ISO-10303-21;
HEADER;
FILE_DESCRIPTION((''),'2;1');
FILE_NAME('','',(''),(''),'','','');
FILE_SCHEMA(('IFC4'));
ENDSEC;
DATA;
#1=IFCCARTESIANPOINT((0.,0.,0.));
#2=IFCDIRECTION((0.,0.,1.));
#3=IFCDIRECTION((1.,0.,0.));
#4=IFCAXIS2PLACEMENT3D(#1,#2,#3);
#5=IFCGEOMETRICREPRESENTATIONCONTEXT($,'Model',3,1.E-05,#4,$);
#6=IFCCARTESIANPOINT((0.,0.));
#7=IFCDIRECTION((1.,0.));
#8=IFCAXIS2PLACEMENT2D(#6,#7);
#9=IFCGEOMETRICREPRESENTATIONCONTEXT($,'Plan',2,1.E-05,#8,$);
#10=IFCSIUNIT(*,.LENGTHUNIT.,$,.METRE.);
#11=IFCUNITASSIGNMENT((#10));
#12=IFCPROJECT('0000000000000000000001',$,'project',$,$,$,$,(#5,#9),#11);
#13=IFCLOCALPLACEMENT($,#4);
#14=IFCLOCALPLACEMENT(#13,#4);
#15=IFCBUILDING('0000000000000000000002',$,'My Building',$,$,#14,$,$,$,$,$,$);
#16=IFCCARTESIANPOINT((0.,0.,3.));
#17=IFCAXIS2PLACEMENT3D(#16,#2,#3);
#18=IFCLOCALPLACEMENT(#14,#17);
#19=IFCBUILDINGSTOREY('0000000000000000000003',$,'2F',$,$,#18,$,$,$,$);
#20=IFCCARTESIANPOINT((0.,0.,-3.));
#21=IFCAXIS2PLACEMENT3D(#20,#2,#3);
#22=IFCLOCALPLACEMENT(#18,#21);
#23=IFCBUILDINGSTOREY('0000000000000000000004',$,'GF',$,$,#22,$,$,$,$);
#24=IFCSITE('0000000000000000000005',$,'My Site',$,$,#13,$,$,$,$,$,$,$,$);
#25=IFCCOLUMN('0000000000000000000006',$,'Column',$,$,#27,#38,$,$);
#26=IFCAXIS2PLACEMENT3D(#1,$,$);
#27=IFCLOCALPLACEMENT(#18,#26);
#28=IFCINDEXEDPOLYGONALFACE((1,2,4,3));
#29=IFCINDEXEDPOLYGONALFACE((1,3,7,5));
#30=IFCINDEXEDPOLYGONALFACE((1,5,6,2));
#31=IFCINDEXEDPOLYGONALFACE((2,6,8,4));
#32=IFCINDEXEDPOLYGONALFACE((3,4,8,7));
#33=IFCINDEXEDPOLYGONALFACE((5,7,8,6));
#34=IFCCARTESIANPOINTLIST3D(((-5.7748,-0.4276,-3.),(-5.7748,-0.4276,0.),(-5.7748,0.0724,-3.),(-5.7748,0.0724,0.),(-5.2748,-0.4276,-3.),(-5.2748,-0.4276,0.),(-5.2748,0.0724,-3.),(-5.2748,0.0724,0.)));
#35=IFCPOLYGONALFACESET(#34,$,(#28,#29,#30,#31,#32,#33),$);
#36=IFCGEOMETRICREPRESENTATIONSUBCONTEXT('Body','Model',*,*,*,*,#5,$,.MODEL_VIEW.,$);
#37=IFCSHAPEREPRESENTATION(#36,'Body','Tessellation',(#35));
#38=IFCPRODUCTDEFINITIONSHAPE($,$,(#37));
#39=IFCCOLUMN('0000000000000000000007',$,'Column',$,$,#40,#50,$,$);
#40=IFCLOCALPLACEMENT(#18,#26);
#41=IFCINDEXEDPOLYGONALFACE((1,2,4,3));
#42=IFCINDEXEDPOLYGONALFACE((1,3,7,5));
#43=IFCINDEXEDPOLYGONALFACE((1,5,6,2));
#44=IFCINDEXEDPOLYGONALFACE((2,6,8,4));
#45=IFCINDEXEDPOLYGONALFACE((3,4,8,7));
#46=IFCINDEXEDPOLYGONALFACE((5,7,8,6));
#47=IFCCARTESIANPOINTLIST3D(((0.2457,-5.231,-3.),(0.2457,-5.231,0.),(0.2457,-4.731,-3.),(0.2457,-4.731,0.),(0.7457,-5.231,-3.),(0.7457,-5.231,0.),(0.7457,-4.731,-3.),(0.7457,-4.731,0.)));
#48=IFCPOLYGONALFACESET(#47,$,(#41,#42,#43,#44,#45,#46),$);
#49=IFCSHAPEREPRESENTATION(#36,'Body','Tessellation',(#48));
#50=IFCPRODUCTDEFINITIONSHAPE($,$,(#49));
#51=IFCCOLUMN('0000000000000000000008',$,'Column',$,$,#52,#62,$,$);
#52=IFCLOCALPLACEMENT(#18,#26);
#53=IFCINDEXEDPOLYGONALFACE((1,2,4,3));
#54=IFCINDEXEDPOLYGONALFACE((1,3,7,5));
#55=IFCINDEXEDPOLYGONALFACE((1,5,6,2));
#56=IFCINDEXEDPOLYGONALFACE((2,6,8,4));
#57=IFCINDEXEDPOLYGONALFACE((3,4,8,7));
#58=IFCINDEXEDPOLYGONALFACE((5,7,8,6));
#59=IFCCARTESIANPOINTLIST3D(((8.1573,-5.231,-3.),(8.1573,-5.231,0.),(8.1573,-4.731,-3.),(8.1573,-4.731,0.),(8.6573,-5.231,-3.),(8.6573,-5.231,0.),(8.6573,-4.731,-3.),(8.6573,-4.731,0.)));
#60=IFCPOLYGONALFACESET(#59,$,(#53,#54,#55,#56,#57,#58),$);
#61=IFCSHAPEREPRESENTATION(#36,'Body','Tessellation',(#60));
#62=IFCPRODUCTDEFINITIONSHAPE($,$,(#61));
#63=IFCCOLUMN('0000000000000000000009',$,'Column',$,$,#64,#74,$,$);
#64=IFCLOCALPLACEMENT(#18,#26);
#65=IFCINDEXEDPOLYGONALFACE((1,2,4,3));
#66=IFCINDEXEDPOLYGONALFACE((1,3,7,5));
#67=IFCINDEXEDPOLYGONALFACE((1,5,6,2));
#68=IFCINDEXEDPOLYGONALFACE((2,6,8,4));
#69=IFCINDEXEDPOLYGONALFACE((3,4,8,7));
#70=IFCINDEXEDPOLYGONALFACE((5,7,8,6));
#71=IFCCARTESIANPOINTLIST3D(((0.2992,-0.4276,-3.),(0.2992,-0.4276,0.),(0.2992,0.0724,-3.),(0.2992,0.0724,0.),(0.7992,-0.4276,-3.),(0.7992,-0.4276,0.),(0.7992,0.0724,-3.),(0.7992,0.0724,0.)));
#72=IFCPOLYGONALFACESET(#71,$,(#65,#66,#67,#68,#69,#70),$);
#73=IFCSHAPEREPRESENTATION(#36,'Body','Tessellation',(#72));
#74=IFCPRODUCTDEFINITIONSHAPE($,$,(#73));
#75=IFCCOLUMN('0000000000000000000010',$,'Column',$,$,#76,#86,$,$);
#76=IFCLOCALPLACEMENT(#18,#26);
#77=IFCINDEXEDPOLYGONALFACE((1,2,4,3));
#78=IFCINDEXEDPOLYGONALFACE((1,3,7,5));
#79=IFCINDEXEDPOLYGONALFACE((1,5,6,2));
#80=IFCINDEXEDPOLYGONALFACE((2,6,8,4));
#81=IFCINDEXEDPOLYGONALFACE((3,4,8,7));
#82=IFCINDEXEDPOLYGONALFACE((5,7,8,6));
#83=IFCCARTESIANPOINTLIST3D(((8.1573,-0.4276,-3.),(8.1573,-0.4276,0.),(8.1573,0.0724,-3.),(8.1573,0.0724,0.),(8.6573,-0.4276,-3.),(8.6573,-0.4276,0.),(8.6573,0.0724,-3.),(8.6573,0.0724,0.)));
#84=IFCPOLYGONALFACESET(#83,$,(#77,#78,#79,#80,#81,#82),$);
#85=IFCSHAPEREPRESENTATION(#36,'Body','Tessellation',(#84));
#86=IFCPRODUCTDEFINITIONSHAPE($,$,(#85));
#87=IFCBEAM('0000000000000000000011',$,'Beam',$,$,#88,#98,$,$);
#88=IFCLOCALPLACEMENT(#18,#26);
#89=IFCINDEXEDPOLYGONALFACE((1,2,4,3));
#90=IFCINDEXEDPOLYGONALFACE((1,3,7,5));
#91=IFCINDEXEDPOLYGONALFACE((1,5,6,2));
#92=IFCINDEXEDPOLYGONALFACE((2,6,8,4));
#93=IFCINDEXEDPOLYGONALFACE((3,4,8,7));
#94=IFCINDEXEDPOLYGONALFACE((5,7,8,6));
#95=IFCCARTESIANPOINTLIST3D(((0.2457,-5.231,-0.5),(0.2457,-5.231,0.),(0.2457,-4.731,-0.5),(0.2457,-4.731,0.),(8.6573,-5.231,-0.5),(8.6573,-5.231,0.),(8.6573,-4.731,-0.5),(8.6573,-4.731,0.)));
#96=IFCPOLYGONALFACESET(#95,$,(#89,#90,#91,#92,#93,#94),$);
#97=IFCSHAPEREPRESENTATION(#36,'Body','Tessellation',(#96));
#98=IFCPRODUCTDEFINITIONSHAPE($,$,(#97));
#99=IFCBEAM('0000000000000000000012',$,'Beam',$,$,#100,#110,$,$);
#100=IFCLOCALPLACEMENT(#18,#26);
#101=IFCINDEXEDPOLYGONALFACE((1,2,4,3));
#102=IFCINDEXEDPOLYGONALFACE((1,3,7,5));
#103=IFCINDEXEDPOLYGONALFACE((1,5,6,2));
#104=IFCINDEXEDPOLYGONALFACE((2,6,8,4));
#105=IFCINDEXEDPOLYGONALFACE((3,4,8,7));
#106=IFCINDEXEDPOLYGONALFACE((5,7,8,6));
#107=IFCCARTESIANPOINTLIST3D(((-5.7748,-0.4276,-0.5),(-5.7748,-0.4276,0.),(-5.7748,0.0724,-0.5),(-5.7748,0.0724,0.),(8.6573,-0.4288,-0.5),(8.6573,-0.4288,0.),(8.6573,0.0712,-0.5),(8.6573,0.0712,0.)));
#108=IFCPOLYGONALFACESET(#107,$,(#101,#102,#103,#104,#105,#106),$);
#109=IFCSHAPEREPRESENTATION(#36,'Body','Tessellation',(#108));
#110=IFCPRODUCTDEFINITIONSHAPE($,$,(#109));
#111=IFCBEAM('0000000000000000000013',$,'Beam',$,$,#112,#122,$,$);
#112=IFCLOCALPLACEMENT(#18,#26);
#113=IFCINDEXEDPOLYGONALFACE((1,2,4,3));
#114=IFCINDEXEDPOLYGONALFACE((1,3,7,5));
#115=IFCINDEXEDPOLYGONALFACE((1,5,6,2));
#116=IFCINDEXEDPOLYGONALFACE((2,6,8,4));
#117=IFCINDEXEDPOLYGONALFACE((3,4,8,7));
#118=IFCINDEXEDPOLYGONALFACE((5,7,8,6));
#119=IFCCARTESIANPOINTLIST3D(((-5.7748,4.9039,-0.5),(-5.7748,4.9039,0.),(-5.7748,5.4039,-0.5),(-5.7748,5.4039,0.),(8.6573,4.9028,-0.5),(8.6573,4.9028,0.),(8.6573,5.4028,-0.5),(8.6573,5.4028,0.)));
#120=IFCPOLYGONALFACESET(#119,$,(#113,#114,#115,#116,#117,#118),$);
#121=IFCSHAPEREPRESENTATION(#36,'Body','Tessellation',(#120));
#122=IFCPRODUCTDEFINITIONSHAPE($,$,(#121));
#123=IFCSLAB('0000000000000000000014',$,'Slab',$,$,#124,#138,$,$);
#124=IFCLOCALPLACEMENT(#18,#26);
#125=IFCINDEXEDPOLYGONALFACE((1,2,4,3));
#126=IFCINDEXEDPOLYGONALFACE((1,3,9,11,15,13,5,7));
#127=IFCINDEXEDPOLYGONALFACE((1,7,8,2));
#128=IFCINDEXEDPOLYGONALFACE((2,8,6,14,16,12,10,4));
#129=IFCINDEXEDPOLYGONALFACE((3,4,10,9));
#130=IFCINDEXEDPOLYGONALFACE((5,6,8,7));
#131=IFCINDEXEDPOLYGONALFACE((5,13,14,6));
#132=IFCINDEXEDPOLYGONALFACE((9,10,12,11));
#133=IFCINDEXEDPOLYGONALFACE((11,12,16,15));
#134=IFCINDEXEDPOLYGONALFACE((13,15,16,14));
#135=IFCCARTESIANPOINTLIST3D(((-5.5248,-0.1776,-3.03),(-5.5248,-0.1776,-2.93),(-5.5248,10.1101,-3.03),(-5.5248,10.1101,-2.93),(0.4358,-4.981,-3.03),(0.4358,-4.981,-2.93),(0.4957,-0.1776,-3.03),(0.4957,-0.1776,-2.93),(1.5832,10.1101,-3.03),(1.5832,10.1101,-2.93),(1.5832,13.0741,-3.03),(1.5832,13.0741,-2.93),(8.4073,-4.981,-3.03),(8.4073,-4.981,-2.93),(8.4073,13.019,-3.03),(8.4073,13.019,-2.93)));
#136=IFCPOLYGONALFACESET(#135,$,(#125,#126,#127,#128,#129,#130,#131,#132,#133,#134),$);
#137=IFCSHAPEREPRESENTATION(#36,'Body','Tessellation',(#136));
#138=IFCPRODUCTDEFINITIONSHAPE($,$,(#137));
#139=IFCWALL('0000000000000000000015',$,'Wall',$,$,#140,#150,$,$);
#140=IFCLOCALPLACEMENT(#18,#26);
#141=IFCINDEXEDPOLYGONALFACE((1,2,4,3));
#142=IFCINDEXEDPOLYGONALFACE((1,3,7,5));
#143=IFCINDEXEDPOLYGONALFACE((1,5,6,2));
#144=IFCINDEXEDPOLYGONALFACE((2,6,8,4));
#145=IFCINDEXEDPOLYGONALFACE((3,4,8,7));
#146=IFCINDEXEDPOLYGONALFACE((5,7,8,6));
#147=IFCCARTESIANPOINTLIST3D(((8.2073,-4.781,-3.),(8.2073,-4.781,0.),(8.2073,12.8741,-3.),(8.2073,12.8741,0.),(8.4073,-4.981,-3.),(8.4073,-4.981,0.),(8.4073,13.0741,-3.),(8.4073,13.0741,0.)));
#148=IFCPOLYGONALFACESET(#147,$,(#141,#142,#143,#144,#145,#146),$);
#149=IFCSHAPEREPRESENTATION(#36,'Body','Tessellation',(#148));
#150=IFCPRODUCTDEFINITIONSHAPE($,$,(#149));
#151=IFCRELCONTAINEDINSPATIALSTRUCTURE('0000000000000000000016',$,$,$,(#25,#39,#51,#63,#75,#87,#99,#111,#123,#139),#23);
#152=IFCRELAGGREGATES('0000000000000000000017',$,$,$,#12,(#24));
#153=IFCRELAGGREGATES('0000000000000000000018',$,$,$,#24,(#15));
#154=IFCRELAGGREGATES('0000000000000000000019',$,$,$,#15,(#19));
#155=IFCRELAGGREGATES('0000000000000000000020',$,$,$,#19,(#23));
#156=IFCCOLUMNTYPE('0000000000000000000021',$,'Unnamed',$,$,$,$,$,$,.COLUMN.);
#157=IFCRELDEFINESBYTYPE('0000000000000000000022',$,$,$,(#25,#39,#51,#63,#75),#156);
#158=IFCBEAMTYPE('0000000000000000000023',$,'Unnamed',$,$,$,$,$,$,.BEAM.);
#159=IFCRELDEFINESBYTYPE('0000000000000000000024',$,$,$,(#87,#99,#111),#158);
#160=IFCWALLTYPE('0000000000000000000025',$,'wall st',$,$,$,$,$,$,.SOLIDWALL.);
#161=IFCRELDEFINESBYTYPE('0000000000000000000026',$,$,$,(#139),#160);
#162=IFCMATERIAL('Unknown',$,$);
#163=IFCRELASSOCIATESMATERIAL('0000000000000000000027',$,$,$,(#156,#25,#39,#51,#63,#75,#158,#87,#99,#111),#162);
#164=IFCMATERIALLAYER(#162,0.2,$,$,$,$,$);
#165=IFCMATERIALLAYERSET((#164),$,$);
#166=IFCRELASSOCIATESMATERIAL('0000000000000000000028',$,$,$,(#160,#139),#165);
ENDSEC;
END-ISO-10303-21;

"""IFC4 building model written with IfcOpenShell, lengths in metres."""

from ifc_helpers import new_model, si_unit, frame, origin_with_axes, origin_2d_with_axis, place, context, subcontext, project, spatial, line, indexed_curve, rectangle, outline, extrude, material, layer, layer_set, layer_usage, material_profile, profile_set, profile_usage, type_object, element, save


model = new_model("IFC4")

# Units and contexts
model_context = context("Model", 3, precision=1e-05, world=origin_with_axes())
plan_context = context("Plan", 2, precision=1e-05, world=origin_2d_with_axis())
body_context_1 = subcontext(model_context, "Body", "Model", "MODEL_VIEW")
ifc_project = project(units=[si_unit("LENGTHUNIT", "METRE")], contexts=[model_context, plan_context])

# Site, building, storeys
site_placement = place(None, origin_with_axes())
site = spatial("IfcSite", under=ifc_project, at=site_placement, Name="My Site")
building_placement = place(site_placement, origin_with_axes())
building = spatial("IfcBuilding", under=site, at=building_placement, Name="My Building")
storey_1_placement = place(building_placement, frame((0.0, 0.0, 3.0), z_axis=(0.0, 0.0, 1.0), x_axis=(1.0, 0.0, 0.0)))
storey_1 = spatial("IfcBuildingStorey", under=building, at=storey_1_placement, Name="2F")
storey_2_placement = place(storey_1_placement, frame((0.0, 0.0, -3.0), z_axis=(0.0, 0.0, 1.0), x_axis=(1.0, 0.0, 0.0)))
storey_2 = spatial("IfcBuildingStorey", under=storey_1, at=storey_2_placement, Name="GF")

# Columns
ifc_material = material(Name="Unknown")
ifc_material_profile_1 = material_profile(ifc_material, rectangle(XDim=0.5, YDim=0.5))
ifc_profile_set_1 = profile_set([ifc_material_profile_1])
ifc_profile_usage_1 = profile_usage(ifc_profile_set_1, cardinal=5)
column_type = type_object("IfcColumnType", Name="Unnamed", PredefinedType="COLUMN", material=ifc_profile_set_1)
column_1_placement = place(storey_2_placement, frame((-5.5248, -0.1776, 0.0), z_axis=(0.0, 0.0, 1.0), x_axis=(1.0, 0.0, 0.0)))
element("IfcColumn", 1, at=column_1_placement, inside=storey_2, type_object=column_type, material=ifc_profile_usage_1, Name="Column", context=body_context_1, shape_type="SweptSolid", body=[
    extrude(rectangle(XDim=0.5, YDim=0.5), origin_with_axes(), (0.0, 0.0, 1.0), 3.0),
])
ifc_profile_usage_2 = profile_usage(ifc_profile_set_1, cardinal=5)
column_2_placement = place(storey_2_placement, frame((0.4957, -4.981, 0.0), z_axis=(0.0, 0.0, 1.0), x_axis=(1.0, 0.0, 0.0)))
element("IfcColumn", 2, at=column_2_placement, inside=storey_2, type_object=column_type, material=ifc_profile_usage_2, Name="Column", context=body_context_1, shape_type="SweptSolid", body=[
    extrude(rectangle(XDim=0.5, YDim=0.5), origin_with_axes(), (0.0, 0.0, 1.0), 3.0),
])
ifc_profile_usage_3 = profile_usage(ifc_profile_set_1, cardinal=5)
column_3_placement = place(storey_2_placement, frame((8.4073, -4.981, 0.0), z_axis=(0.0, 0.0, 1.0), x_axis=(1.0, 0.0, 0.0)))
element("IfcColumn", 3, at=column_3_placement, inside=storey_2, type_object=column_type, material=ifc_profile_usage_3, Name="Column", context=body_context_1, shape_type="SweptSolid", body=[
    extrude(rectangle(XDim=0.5, YDim=0.5), origin_with_axes(), (0.0, 0.0, 1.0), 3.0),
])
ifc_profile_usage_4 = profile_usage(ifc_profile_set_1, cardinal=5)
column_4_placement = place(storey_2_placement, frame((0.5492, -0.1776, 0.0), z_axis=(0.0, 0.0, 1.0), x_axis=(1.0, 0.0, 0.0)))
element("IfcColumn", 4, at=column_4_placement, inside=storey_2, type_object=column_type, material=ifc_profile_usage_4, Name="Column", context=body_context_1, shape_type="SweptSolid", body=[
    extrude(rectangle(XDim=0.5, YDim=0.5), origin_with_axes(), (0.0, 0.0, 1.0), 3.0),
])
ifc_profile_usage_5 = profile_usage(ifc_profile_set_1, cardinal=5)
column_5_placement = place(storey_2_placement, frame((8.4073, -0.1776, 0.0), z_axis=(0.0, 0.0, 1.0), x_axis=(1.0, 0.0, 0.0)))
element("IfcColumn", 5, at=column_5_placement, inside=storey_2, type_object=column_type, material=ifc_profile_usage_5, Name="Column", context=body_context_1, shape_type="SweptSolid", body=[
    extrude(rectangle(XDim=0.5, YDim=0.5), origin_with_axes(), (0.0, 0.0, 1.0), 3.0),
])

# Beams
ifc_material_profile_2 = material_profile(ifc_material, rectangle(XDim=0.5, YDim=0.5))
ifc_profile_set_2 = profile_set([ifc_material_profile_2])
ifc_profile_usage_6 = profile_usage(ifc_profile_set_2, cardinal=6)
beam_type = type_object("IfcBeamType", Name="Unnamed", PredefinedType="BEAM", material=ifc_profile_set_2)
beam_1_placement = place(storey_2_placement, frame((0.2457, -5.231, 2.75), z_axis=(1.0, 0.0, 0.0), x_axis=(0.0, 1.0, 0.0)))
element("IfcBeam", 6, at=beam_1_placement, inside=storey_2, type_object=beam_type, material=ifc_profile_usage_6, Name="Beam", context=body_context_1, shape_type="SweptSolid", body=[
    extrude(rectangle(XDim=0.5, YDim=0.5), frame((0.25, 0.0, 0.0), z_axis=(0.0, 0.0, 1.0), x_axis=(1.0, 0.0, 0.0)), (0.0, 0.0, 1.0), 8.4116),
])
ifc_profile_usage_7 = profile_usage(ifc_profile_set_2, cardinal=9)
beam_2_placement = place(storey_2_placement, frame((-5.7748, -0.4276, 3.0), z_axis=(1.0, -0.000081, 0.0), x_axis=(0.000081, 1.0, 0.0)))
element("IfcBeam", 7, at=beam_2_placement, inside=storey_2, type_object=beam_type, material=ifc_profile_usage_7, Name="Beam", context=body_context_1, shape_type="SweptSolid", body=[
    extrude(rectangle(XDim=0.5, YDim=0.5), frame((0.25, -0.25, 0.0), z_axis=(0.0, 0.0, 1.0), x_axis=(1.0, 0.0, 0.0)), (0.0, 0.0, 1.0), 14.4321),
])
ifc_profile_usage_8 = profile_usage(ifc_profile_set_2, cardinal=9)
beam_3_placement = place(storey_2_placement, frame((-5.7748, 4.9039, 3.0), z_axis=(1.0, -0.000081, 0.0), x_axis=(0.000081, 1.0, 0.0)))
element("IfcBeam", 8, at=beam_3_placement, inside=storey_2, type_object=beam_type, material=ifc_profile_usage_8, Name="Beam", context=body_context_1, shape_type="SweptSolid", body=[
    extrude(rectangle(XDim=0.5, YDim=0.5), frame((0.25, -0.25, 0.0), z_axis=(0.0, 0.0, 1.0), x_axis=(1.0, 0.0, 0.0)), (0.0, 0.0, 1.0), 14.4321),
])

# Slab
slab_1_placement = place(storey_2_placement, frame((8.4073, -4.981, 0.07), z_axis=(0.0, 0.0, 1.0), x_axis=(1.0, 0.0, 0.0)))
element("IfcSlab", 9, at=slab_1_placement, inside=storey_2, Name="Slab", context=body_context_1, shape_type="SweptSolid", body=[
    extrude(outline(indexed_curve([(0.0, 0.0), (0.0, 18.0), (-6.8241, 18.055), (-6.8241, 15.091), (-13.9321, 15.091), (-13.9321, 4.8033), (-7.9116, 4.8033), (-7.9715, 0.0), (0.0, 0.0)])), frame((0.0, 0.0, -0.1), z_axis=(0.0, 0.0, 1.0), x_axis=(1.0, 0.0, 0.0)), (0.0, 0.0, 1.0), 0.1),
])

# Shared definitions
ifc_layer_1 = layer(ifc_material, 0.2)
ifc_layer_set_1 = layer_set([ifc_layer_1])
wall_type = type_object("IfcWallType", Name="wall st", PredefinedType="SOLIDWALL", material=ifc_layer_set_1)

# Wall
ifc_layer_usage_1 = layer_usage(ifc_layer_set_1, "AXIS2", "POSITIVE", 0.0)
wall_1_placement = place(storey_2_placement, frame((8.4073, -4.981, 0.0), z_axis=(0.0, 0.0, 1.0), x_axis=(0.0, 1.0, 0.0)))
element("IfcWall", 10, at=wall_1_placement, inside=storey_2, type_object=wall_type, material=ifc_layer_usage_1, Name="Wall", context=body_context_1, shape_type="SweptSolid", body=[
    extrude(outline(indexed_curve([(0.0, 0.0), (0.2, 0.2), (17.855, 0.2), (18.055, 0.0)], segments=[line(1, 2, 3, 4, 1)])), origin_with_axes(), (0.0, 0.0, 1.0), 3.0),
])

save(model, "model.ifc")
